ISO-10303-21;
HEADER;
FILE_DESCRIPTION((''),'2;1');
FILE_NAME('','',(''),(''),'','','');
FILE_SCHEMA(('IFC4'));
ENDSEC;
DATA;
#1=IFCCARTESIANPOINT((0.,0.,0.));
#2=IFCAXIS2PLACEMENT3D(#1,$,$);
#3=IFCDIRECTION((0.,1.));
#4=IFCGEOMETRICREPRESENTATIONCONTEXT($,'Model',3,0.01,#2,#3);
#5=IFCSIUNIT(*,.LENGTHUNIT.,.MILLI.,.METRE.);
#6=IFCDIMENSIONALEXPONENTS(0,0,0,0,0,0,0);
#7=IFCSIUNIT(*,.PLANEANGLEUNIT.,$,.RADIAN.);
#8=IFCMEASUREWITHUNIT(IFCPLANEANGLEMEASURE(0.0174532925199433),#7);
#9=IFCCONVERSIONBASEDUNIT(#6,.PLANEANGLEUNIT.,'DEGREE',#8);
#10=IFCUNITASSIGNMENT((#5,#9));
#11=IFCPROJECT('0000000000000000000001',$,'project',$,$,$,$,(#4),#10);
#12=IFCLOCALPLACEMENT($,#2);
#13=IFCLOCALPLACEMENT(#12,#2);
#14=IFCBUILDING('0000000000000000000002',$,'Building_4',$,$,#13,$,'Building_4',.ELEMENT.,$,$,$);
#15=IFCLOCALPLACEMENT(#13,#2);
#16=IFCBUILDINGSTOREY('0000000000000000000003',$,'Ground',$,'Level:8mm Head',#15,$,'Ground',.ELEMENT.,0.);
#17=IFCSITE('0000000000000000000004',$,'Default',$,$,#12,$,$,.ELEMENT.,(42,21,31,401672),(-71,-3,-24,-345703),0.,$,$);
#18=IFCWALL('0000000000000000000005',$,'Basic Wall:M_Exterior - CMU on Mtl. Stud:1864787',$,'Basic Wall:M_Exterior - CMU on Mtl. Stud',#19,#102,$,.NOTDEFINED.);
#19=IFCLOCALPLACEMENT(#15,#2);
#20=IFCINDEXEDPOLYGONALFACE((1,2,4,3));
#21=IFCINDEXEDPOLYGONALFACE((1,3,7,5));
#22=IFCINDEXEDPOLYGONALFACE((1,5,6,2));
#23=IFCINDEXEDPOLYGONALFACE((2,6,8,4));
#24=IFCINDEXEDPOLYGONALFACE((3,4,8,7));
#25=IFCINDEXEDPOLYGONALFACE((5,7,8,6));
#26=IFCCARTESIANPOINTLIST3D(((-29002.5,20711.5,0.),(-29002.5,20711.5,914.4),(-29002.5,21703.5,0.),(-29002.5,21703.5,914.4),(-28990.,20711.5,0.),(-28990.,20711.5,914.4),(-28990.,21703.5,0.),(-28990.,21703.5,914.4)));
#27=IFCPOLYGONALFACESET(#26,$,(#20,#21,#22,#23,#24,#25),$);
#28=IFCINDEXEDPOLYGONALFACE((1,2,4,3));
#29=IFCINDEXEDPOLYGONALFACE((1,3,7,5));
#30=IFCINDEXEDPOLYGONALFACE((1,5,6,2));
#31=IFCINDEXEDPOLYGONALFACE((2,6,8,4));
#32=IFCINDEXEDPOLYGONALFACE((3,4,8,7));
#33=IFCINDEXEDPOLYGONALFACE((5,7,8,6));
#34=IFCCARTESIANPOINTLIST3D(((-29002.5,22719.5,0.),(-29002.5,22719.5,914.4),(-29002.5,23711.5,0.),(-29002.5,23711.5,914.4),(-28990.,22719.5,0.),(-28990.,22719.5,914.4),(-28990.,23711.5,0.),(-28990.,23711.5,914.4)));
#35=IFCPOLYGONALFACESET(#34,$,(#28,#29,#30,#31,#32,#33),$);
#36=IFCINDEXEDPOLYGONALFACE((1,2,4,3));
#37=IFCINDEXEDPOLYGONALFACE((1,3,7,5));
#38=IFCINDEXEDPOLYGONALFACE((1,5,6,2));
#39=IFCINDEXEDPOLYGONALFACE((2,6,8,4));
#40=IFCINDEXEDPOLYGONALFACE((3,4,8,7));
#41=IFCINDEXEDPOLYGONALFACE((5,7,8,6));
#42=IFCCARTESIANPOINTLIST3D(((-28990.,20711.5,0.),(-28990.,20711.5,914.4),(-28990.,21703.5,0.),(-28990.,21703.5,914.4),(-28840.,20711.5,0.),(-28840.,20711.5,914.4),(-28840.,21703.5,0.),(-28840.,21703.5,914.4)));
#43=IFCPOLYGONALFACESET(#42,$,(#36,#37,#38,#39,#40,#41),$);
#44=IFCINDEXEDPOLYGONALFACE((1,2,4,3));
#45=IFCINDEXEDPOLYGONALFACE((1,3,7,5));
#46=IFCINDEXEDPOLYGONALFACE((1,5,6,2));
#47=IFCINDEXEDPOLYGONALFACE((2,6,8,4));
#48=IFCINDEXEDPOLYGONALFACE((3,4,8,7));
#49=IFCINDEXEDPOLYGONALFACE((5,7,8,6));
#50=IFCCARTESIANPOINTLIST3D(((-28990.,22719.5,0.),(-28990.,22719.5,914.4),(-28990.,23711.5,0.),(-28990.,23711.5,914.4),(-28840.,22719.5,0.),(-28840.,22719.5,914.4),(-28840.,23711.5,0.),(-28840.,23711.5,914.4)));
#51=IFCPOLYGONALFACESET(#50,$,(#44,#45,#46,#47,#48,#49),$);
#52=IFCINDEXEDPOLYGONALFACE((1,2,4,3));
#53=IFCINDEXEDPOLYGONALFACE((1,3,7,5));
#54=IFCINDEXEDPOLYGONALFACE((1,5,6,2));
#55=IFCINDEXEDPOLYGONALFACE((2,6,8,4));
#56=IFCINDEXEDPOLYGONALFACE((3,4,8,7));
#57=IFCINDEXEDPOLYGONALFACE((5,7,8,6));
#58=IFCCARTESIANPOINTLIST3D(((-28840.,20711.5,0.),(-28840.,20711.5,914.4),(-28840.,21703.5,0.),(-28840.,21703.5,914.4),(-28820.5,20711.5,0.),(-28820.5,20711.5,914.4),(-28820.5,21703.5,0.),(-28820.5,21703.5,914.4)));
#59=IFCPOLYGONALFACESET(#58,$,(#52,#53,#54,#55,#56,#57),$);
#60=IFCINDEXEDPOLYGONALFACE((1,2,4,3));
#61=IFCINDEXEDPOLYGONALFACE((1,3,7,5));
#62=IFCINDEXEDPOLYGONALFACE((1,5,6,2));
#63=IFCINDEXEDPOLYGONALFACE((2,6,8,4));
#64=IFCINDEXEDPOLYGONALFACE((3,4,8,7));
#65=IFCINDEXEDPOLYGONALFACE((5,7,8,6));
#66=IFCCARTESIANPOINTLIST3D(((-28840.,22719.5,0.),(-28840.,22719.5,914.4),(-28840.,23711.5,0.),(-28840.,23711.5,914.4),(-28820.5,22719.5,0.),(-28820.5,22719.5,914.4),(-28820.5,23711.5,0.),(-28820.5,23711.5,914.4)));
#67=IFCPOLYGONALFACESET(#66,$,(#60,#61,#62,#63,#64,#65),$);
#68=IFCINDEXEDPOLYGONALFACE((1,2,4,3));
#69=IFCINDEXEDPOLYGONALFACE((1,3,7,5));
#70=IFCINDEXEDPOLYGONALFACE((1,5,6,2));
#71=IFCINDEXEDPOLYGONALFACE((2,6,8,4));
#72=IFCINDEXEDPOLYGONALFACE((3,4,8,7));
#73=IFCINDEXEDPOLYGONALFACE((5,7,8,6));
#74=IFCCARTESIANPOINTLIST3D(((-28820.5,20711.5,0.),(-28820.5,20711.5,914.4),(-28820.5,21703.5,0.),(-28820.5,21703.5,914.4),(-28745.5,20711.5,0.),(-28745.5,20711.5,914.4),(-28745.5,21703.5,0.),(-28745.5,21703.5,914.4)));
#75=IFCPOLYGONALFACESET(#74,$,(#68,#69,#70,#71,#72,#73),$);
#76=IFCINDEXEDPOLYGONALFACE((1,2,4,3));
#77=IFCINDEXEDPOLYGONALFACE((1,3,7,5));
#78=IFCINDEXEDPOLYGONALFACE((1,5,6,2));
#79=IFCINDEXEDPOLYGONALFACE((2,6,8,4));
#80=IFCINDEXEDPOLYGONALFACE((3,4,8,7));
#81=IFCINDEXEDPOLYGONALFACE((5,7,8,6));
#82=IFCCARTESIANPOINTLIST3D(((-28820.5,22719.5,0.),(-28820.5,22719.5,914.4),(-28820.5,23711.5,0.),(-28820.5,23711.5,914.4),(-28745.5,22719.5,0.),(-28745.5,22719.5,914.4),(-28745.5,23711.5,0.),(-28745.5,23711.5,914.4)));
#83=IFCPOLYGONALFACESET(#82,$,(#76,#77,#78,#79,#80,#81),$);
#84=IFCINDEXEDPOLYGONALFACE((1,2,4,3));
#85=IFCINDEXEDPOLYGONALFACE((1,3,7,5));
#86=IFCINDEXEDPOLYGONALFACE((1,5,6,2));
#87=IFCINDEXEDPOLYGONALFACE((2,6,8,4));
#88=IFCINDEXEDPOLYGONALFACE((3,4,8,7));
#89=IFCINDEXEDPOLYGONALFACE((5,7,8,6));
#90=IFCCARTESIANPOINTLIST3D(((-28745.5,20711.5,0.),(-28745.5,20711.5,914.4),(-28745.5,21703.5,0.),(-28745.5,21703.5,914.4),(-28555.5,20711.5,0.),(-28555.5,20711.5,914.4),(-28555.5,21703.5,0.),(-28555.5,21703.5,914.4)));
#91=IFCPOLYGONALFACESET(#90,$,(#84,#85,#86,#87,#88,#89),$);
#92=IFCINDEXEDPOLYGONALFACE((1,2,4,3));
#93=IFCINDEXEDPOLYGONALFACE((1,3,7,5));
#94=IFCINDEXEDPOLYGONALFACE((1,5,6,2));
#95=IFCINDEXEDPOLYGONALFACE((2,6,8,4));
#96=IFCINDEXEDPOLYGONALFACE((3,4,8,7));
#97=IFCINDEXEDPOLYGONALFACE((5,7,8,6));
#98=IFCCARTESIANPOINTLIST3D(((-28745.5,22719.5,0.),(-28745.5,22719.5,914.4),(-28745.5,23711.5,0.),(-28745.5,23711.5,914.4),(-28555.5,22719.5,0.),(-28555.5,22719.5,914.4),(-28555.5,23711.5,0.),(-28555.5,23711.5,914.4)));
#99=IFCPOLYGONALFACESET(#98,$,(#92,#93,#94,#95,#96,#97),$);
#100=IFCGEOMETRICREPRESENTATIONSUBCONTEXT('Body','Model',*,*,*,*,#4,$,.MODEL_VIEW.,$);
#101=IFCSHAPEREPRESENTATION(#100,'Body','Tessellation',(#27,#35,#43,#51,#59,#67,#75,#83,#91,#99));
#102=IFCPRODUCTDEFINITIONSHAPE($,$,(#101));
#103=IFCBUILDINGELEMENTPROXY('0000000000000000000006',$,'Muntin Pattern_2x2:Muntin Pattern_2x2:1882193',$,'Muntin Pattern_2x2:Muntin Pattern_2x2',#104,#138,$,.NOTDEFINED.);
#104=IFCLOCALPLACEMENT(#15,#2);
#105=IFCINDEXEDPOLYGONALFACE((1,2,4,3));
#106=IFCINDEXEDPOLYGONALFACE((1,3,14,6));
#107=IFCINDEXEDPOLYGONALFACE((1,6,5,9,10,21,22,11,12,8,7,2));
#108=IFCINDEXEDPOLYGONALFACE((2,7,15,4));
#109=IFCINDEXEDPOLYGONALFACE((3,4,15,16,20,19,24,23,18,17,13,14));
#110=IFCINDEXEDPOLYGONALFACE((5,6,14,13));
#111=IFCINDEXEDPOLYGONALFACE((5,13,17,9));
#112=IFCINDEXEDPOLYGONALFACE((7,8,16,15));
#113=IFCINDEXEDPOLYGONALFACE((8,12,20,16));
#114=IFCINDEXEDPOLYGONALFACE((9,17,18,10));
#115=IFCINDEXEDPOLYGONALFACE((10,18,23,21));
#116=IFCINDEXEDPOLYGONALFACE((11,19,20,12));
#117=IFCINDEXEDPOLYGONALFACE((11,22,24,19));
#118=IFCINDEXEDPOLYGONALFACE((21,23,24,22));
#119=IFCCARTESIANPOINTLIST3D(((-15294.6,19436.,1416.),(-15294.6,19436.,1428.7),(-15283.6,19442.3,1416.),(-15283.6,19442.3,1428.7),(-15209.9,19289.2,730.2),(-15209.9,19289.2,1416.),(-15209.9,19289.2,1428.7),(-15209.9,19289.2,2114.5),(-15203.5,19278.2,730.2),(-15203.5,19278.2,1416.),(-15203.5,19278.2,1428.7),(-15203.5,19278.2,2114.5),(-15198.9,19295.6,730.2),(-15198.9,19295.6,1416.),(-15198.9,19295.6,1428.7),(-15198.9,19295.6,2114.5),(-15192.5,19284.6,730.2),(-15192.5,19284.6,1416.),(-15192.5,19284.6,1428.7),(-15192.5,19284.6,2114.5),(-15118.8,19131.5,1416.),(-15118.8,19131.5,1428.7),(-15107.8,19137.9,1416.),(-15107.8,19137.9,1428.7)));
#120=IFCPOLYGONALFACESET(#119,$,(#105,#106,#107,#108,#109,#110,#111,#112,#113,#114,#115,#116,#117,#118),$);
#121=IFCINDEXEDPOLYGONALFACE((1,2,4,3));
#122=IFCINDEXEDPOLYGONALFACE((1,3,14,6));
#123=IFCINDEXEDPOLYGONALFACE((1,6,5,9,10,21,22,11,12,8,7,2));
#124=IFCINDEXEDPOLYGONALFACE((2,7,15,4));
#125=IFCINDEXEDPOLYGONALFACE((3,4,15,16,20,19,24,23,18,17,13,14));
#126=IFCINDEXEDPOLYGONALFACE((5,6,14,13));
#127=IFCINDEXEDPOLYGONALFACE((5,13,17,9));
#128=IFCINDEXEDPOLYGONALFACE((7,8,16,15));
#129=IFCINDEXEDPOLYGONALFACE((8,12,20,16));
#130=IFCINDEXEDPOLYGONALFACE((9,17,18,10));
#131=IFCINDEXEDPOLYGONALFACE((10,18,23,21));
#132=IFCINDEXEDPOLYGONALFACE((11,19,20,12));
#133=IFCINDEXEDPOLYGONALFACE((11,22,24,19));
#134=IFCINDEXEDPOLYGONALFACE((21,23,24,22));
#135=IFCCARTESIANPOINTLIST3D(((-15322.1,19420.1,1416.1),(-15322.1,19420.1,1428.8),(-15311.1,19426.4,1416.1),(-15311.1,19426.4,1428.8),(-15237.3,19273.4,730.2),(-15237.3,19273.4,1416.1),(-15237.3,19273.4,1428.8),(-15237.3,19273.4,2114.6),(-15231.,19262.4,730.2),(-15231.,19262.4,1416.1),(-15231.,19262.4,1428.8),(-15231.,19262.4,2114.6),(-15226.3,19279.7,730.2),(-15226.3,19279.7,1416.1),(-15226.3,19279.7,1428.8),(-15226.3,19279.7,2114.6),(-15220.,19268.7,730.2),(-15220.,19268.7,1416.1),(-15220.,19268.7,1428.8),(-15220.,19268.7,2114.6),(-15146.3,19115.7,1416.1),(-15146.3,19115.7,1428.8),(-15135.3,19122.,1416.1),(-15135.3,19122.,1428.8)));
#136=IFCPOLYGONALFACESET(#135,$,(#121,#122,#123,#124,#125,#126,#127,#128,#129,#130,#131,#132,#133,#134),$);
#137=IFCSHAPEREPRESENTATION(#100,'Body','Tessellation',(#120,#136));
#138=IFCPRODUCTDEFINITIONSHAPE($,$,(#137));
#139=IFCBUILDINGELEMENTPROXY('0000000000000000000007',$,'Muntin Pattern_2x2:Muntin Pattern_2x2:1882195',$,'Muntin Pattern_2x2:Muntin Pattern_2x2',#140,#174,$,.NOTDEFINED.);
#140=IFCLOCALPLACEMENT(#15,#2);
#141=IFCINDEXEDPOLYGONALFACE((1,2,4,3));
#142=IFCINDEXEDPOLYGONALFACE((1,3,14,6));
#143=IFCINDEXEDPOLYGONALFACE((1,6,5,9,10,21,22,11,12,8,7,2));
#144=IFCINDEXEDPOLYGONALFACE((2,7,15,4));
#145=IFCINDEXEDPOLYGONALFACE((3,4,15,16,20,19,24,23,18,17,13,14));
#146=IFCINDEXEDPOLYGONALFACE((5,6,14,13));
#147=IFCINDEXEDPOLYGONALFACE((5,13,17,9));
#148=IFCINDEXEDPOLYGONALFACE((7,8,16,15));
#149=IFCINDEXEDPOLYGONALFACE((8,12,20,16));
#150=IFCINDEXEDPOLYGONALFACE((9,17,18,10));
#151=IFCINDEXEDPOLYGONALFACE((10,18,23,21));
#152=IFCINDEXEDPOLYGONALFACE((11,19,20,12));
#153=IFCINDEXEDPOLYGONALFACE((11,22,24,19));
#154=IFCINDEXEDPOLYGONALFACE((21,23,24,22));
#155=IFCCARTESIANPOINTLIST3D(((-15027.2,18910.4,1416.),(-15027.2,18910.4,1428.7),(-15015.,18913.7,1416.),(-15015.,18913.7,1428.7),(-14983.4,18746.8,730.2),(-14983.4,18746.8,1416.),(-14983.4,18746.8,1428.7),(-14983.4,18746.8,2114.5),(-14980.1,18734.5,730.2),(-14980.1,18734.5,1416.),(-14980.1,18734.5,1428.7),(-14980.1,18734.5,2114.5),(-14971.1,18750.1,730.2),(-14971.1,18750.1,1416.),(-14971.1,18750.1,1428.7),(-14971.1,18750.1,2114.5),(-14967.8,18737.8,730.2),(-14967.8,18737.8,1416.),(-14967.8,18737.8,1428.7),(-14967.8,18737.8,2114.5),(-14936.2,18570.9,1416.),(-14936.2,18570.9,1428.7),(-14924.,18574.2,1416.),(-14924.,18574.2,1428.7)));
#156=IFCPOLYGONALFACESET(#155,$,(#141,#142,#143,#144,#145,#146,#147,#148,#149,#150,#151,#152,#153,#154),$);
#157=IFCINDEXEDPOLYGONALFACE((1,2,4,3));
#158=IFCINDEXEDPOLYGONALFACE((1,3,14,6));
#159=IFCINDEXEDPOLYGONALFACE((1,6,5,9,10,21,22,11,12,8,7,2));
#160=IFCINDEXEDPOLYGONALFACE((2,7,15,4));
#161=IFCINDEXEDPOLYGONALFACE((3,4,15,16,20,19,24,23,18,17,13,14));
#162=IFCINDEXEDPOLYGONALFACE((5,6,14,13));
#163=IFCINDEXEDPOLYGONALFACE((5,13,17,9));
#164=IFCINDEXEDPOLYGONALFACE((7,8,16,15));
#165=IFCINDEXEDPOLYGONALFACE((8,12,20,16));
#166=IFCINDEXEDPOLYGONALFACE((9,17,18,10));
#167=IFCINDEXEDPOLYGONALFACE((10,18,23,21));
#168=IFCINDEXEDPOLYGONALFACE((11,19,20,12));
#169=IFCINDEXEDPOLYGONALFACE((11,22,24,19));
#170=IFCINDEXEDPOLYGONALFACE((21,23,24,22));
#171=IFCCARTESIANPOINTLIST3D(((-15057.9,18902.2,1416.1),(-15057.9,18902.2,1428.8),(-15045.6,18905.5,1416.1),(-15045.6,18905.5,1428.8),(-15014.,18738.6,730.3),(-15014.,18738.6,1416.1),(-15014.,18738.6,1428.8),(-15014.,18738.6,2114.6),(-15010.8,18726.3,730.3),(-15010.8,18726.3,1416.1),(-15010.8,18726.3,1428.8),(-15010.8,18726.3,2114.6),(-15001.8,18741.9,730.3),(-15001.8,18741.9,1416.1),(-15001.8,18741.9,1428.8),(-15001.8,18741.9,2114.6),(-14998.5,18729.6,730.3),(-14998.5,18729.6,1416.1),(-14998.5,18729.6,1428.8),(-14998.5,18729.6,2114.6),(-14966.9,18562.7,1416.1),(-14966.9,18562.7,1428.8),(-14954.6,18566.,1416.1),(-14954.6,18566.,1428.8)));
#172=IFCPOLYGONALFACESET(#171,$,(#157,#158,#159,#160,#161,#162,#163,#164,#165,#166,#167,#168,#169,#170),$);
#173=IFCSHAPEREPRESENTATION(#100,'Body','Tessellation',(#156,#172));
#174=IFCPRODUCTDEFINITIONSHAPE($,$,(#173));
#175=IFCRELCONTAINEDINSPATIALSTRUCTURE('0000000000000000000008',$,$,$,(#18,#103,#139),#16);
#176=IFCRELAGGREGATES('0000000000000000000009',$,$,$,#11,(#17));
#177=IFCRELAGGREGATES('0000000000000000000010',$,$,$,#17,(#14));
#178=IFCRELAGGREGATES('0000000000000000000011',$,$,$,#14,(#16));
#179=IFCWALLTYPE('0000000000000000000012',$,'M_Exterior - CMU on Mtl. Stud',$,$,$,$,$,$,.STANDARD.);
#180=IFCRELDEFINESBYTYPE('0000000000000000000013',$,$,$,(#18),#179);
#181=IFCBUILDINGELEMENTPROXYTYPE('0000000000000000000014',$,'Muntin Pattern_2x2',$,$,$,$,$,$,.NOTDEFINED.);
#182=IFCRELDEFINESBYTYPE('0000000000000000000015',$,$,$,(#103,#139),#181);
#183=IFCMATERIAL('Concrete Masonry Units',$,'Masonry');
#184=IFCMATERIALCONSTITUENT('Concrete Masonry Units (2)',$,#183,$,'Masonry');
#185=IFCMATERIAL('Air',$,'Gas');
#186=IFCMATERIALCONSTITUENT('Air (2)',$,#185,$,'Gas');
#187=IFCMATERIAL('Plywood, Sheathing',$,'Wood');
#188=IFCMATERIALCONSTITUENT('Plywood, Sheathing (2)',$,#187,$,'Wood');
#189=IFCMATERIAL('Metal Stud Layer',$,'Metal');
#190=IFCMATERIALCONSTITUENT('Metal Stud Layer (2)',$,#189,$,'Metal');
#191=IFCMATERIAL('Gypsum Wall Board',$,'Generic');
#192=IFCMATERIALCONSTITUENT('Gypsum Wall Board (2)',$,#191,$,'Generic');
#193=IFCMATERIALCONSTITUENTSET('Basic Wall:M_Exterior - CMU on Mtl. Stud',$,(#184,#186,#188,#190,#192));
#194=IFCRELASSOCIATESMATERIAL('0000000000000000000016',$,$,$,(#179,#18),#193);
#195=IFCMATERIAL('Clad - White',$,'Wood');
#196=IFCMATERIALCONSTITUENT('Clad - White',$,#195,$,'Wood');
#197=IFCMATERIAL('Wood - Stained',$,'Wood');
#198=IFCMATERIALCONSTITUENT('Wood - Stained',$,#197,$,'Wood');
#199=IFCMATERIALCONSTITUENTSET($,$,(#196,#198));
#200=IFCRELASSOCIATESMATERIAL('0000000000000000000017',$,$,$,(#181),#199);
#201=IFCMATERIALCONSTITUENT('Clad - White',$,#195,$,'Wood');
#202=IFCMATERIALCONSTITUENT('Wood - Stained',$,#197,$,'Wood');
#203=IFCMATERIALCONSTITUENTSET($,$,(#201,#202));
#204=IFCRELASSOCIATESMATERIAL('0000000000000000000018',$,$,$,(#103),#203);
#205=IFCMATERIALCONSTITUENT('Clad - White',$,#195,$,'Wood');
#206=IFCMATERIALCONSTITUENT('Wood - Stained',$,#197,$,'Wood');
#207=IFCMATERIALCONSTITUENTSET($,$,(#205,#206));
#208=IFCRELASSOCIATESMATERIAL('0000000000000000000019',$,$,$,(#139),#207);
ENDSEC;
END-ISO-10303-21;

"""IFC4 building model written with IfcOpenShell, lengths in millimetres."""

from ifc_helpers import new_model, entity, si_unit, converted_unit, direction, frame, origin, place, context, subcontext, project, spatial, indexed_curve, outline, extrude, source, transform, mapped, material, constituent, constituent_set, type_object, type_shapes, element, save


model = new_model("IFC4")

# Units and contexts
model_context = context("Model", 3, precision=0.01, world=origin(), true_north=direction((0.0, 1.0)))
body_context = subcontext(model_context, "Body", "Model", "MODEL_VIEW")
ifc_project = project(units=[si_unit("LENGTHUNIT", "METRE", prefix="MILLI"), converted_unit("PLANEANGLEUNIT", "DEGREE", entity("IfcPlaneAngleMeasure", 0.0174532925199433), si_unit("PLANEANGLEUNIT", "RADIAN"), dimensions=[0, 0, 0, 0, 0, 0, 0])], contexts=[model_context])

# Site, building, storey
site_placement = place(None, origin())
site = spatial("IfcSite", under=ifc_project, at=site_placement, Name="Default", CompositionType="ELEMENT", RefLatitude=(42, 21, 31, 401672), RefLongitude=(-71, -3, -24, -345703), RefElevation=0.0)
building_placement = place(site_placement, origin())
building = spatial("IfcBuilding", under=site, at=building_placement, Name="Building_4", LongName="Building_4", CompositionType="ELEMENT")
storey_placement = place(building_placement, origin())
storey = spatial("IfcBuildingStorey", under=building, at=storey_placement, Name="Ground", ObjectType="Level:8mm Head", LongName="Ground", CompositionType="ELEMENT", Elevation=0.0)

# Shared definitions
ifc_material_1 = material(Name="Air", Category="Gas")
ifc_material_2 = material(Name="Plywood, Sheathing", Category="Wood")
ifc_material_3 = material(Name="Metal Stud Layer", Category="Metal")
ifc_material_4 = material(Name="Gypsum Wall Board", Category="Generic")

# Wall, opening
ifc_material_5 = material(Name="Concrete Masonry Units", Category="Masonry")
ifc_constituent_1 = constituent(ifc_material_5, Name="Concrete Masonry Units (2)", Category="Masonry")
ifc_constituent_2 = constituent(ifc_material_1, Name="Air (2)", Category="Gas")
ifc_constituent_3 = constituent(ifc_material_2, Name="Plywood, Sheathing (2)", Category="Wood")
ifc_constituent_4 = constituent(ifc_material_3, Name="Metal Stud Layer (2)", Category="Metal")
ifc_constituent_5 = constituent(ifc_material_4, Name="Gypsum Wall Board (2)", Category="Generic")
ifc_constituent_set_1 = constituent_set(constituents=[ifc_constituent_1, ifc_constituent_2, ifc_constituent_3, ifc_constituent_4, ifc_constituent_5], Name="Basic Wall:M_Exterior - CMU on Mtl. Stud")
wall_type_1 = type_object("IfcWallType", Name="M_Exterior - CMU on Mtl. Stud", PredefinedType="STANDARD", material=ifc_constituent_set_1)
wall_1_placement = place(storey_placement, frame((-28779.0, 23711.5, 0.0), z_axis=(0.0, 0.0, 1.0), x_axis=(0.0, -1.0, 0.0)))
wall_1 = element("IfcWall", 1, at=wall_1_placement, inside=storey, type_object=wall_type_1, material=ifc_constituent_set_1, Name="Basic Wall:M_Exterior - CMU on Mtl. Stud:1864787", ObjectType="Basic Wall:M_Exterior - CMU on Mtl. Stud", PredefinedType="NOTDEFINED", context=body_context, shape_type="SweptSolid", body=[
    extrude(outline(indexed_curve([(-6.2, -496.0), (6.2, -496.0), (6.2, 496.0), (-6.2, 496.0), (-6.2, -496.0)], self_intersect=False)), frame((2504.0, -217.2, 0.0), z_axis=(0.0, 0.0, 1.0), x_axis=(0.0, 1.0, 0.0)), (0.0, 0.0, 1.0), 914.4),
    extrude(outline(indexed_curve([(-6.2, -496.0), (6.2, -496.0), (6.2, 496.0), (-6.2, 496.0), (-6.2, -496.0)], self_intersect=False)), frame((496.0, -217.2, 0.0), z_axis=(0.0, 0.0, 1.0), x_axis=(0.0, 1.0, 0.0)), (0.0, 0.0, 1.0), 914.4),
    extrude(outline(indexed_curve([(-496.0, -75.0), (496.0, -75.0), (496.0, 75.0), (-496.0, 75.0), (-496.0, -75.0)], self_intersect=False)), frame((2504.0, -136.0, 0.0)), (0.0, 0.0, 1.0), 914.4),
    extrude(outline(indexed_curve([(-496.0, -75.0), (496.0, -75.0), (496.0, 75.0), (-496.0, 75.0), (-496.0, -75.0)], self_intersect=False)), frame((496.0, -136.0, 0.0)), (0.0, 0.0, 1.0), 914.4),
    extrude(outline(indexed_curve([(-496.0, -9.7), (496.0, -9.7), (496.0, 9.8), (-496.0, 9.8), (-496.0, -9.7)], self_intersect=False)), frame((2504.0, -51.3, 0.0)), (0.0, 0.0, 1.0), 914.4),
    extrude(outline(indexed_curve([(-496.0, -9.7), (496.0, -9.7), (496.0, 9.8), (-496.0, 9.8), (-496.0, -9.7)], self_intersect=False)), frame((496.0, -51.3, 0.0)), (0.0, 0.0, 1.0), 914.4),
    extrude(outline(indexed_curve([(-496.0, -37.5), (496.0, -37.5), (496.0, 37.5), (-496.0, 37.5), (-496.0, -37.5)], self_intersect=False)), frame((2504.0, -4.0, 0.0)), (0.0, 0.0, 1.0), 914.4),
    extrude(outline(indexed_curve([(-496.0, -37.5), (496.0, -37.5), (496.0, 37.5), (-496.0, 37.5), (-496.0, -37.5)], self_intersect=False)), frame((496.0, -4.0, 0.0)), (0.0, 0.0, 1.0), 914.4),
    extrude(outline(indexed_curve([(-95.0, -496.0), (95.0, -496.0), (95.0, 496.0), (-95.0, 496.0), (-95.0, -496.0)], self_intersect=False)), frame((2504.0, 128.5, 0.0), z_axis=(0.0, 0.0, 1.0), x_axis=(0.0, -1.0, 0.0)), (0.0, 0.0, 1.0), 914.4),
    extrude(outline(indexed_curve([(-95.0, -496.0), (95.0, -496.0), (95.0, 496.0), (-95.0, 496.0), (-95.0, -496.0)], self_intersect=False)), frame((496.0, 128.5, 0.0), z_axis=(0.0, 0.0, 1.0), x_axis=(0.0, -1.0, 0.0)), (0.0, 0.0, 1.0), 914.4),
])
opening_1_placement = place(wall_1_placement, origin())
element("IfcOpeningElement", 2, at=opening_1_placement, cuts=wall_1, PredefinedType="OPENING", context=body_context, shape_type="SweptSolid", body=[
    extrude(outline(indexed_curve([(-508.0, -1117.6), (508.0, -1117.6), (508.0, 1117.6), (-508.0, 1117.6), (-508.0, -1117.6)], self_intersect=False)), frame((1500.0, -1747.5, 1117.6), z_axis=(0.0, 1.0, 0.0), x_axis=(-1.0, 0.0, 0.0)), (0.0, 0.0, 1.0), 3048.0),
])

# Building element proxies
ifc_material_6 = material(Name="Clad - White", Category="Wood")
ifc_constituent_6 = constituent(ifc_material_6, Name="Clad - White", Category="Wood")
ifc_material_7 = material(Name="Wood - Stained", Category="Wood")
ifc_constituent_7 = constituent(ifc_material_7, Name="Wood - Stained", Category="Wood")
ifc_constituent_set_2 = constituent_set(constituents=[ifc_constituent_6, ifc_constituent_7])
ifc_constituent_8 = constituent(ifc_material_6, Name="Clad - White", Category="Wood")
ifc_constituent_9 = constituent(ifc_material_7, Name="Wood - Stained", Category="Wood")
ifc_constituent_set_3 = constituent_set(constituents=[ifc_constituent_8, ifc_constituent_9])
building_element_proxy_type_1 = type_object("IfcBuildingElementProxyType", Name="Muntin Pattern_2x2", PredefinedType="NOTDEFINED", material=ifc_constituent_set_3)
shared_shape_1 = source(origin(), body_context, "Body", "SweptSolid", [
    extrude(outline(indexed_curve([(6.4, -6.4), (692.1, -6.4), (692.1, 6.3), (6.4, 6.3), (6.4, 175.8), (-6.3, 175.8), (-6.3, 6.3), (-692.2, 6.3), (-692.2, -6.4), (-6.3, -6.4), (-6.3, -175.8), (6.4, -175.8), (6.4, -6.4)], self_intersect=False)), frame((0.0, 9.5, 692.1), z_axis=(0.0, 1.0, 0.0), x_axis=(0.0, 0.0, 1.0)), (0.0, 0.0, 1.0), 12.7),
    extrude(outline(indexed_curve([(6.4, -6.4), (692.1, -6.4), (692.1, 6.3), (6.4, 6.3), (6.4, 175.8), (-6.3, 175.8), (-6.3, 6.3), (-692.2, 6.3), (-692.2, -6.4), (-6.3, -6.4), (-6.3, -175.8), (6.4, -175.8), (6.4, -6.4)], self_intersect=False)), frame((0.0, -22.2, 692.2), z_axis=(0.0, 1.0, 0.0), x_axis=(0.0, 0.0, 1.0)), (0.0, 0.0, 1.0), 12.7),
])
type_shapes(building_element_proxy_type_1, [shared_shape_1])
proxy_1_placement = place(storey_placement, frame((-15214.9, 19279.0, 730.2), z_axis=(0.0, 0.0, 1.0), x_axis=(0.5, -0.866025, 0.0)))
element("IfcBuildingElementProxy", 3, at=proxy_1_placement, inside=storey, type_object=building_element_proxy_type_1, material=ifc_constituent_set_2, Name="Muntin Pattern_2x2:Muntin Pattern_2x2:1882193", ObjectType="Muntin Pattern_2x2:Muntin Pattern_2x2", PredefinedType="NOTDEFINED", context=body_context, shape_type="MappedRepresentation", body=[
    mapped(shared_shape_1, transform((0.0, 0.0, 0.0), scale=1.0)),
])
ifc_constituent_10 = constituent(ifc_material_6, Name="Clad - White", Category="Wood")
ifc_constituent_11 = constituent(ifc_material_7, Name="Wood - Stained", Category="Wood")
ifc_constituent_set_4 = constituent_set(constituents=[ifc_constituent_10, ifc_constituent_11])
proxy_2_placement = place(storey_placement, frame((-14990.9, 18738.2, 730.3), z_axis=(0.0, 0.0, 1.0), x_axis=(0.258819, -0.965926, 0.0)))
element("IfcBuildingElementProxy", 4, at=proxy_2_placement, inside=storey, type_object=building_element_proxy_type_1, material=ifc_constituent_set_4, Name="Muntin Pattern_2x2:Muntin Pattern_2x2:1882195", ObjectType="Muntin Pattern_2x2:Muntin Pattern_2x2", PredefinedType="NOTDEFINED", context=body_context, shape_type="MappedRepresentation", body=[
    mapped(shared_shape_1, transform((0.0, 0.0, 0.0), scale=1.0)),
])

save(model, "model.ifc")
